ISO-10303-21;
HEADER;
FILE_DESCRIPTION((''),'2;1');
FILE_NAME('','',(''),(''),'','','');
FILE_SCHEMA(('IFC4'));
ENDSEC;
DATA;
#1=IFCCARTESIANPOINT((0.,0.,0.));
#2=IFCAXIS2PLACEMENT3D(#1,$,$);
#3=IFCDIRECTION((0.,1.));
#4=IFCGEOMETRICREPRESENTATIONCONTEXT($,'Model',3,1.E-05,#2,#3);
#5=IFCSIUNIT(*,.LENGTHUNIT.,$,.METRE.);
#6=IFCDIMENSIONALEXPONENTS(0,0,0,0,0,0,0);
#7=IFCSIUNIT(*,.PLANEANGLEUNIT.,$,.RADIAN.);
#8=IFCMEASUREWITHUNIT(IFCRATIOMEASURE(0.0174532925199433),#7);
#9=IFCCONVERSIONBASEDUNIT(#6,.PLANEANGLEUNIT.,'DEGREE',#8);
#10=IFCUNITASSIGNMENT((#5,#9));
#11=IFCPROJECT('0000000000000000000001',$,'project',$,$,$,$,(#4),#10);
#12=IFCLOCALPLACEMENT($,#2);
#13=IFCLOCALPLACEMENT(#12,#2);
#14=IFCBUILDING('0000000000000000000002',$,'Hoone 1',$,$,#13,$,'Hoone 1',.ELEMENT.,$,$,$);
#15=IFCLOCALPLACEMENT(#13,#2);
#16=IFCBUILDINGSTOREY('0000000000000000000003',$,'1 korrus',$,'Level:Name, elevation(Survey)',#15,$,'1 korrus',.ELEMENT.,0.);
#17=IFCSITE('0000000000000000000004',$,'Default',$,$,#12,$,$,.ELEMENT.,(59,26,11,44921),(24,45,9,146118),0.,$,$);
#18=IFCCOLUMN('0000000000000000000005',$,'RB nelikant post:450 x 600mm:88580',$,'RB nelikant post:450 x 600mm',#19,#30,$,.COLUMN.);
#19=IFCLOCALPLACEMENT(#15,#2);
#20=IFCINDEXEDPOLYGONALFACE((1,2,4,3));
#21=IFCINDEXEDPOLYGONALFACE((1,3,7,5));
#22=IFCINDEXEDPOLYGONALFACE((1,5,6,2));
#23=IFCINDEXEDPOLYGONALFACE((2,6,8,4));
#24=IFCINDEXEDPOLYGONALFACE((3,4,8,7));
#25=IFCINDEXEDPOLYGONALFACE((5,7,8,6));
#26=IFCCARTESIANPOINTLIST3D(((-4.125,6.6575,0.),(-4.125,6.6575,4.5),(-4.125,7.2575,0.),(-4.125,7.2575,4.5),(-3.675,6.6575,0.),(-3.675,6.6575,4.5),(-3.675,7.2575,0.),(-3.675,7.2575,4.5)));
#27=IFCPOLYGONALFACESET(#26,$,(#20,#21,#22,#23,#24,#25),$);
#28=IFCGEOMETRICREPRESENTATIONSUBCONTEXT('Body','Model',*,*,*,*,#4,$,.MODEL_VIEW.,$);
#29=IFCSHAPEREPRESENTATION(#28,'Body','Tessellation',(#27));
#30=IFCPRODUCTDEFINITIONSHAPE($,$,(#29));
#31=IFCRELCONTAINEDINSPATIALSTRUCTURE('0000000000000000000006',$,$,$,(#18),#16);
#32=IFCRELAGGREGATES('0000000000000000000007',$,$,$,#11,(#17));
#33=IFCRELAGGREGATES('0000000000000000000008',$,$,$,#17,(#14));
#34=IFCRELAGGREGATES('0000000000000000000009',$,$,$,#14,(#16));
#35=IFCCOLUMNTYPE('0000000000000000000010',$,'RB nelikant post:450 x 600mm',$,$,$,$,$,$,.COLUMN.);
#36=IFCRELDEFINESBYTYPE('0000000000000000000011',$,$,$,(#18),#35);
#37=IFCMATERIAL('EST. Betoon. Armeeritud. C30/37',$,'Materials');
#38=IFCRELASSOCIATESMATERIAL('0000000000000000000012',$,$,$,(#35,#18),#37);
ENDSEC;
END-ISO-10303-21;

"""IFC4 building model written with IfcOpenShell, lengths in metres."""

from ifc_helpers import new_model, entity, si_unit, converted_unit, direction, frame, origin, place, context, subcontext, project, spatial, indexed_curve, outline, extrude, source, transform, mapped, material, type_object, type_shapes, element, save


model = new_model("IFC4")

# Units and contexts
model_context = context("Model", 3, precision=1e-05, world=origin(), true_north=direction((0.0, 1.0)))
body_context = subcontext(model_context, "Body", "Model", "MODEL_VIEW")
ifc_project = project(units=[si_unit("LENGTHUNIT", "METRE"), converted_unit("PLANEANGLEUNIT", "DEGREE", entity("IfcRatioMeasure", 0.0174532925199433), si_unit("PLANEANGLEUNIT", "RADIAN"), dimensions=[0, 0, 0, 0, 0, 0, 0])], contexts=[model_context])

# Site, building, storey
site_placement = place(None, origin())
site = spatial("IfcSite", under=ifc_project, at=site_placement, Name="Default", CompositionType="ELEMENT", RefLatitude=(59, 26, 11, 44921), RefLongitude=(24, 45, 9, 146118), RefElevation=0.0)
building_placement = place(site_placement, origin())
building = spatial("IfcBuilding", under=site, at=building_placement, Name="Hoone 1", LongName="Hoone 1", CompositionType="ELEMENT")
storey_placement = place(building_placement, origin())
storey = spatial("IfcBuildingStorey", under=building, at=storey_placement, Name="1 korrus", ObjectType="Level:Name, elevation(Survey)", LongName="1 korrus", CompositionType="ELEMENT", Elevation=0.0)

# Column
ifc_material_1 = material(Name="EST. Betoon. Armeeritud. C30/37", Category="Materials")
column_type = type_object("IfcColumnType", Name="RB nelikant post:450 x 600mm", PredefinedType="COLUMN", material=ifc_material_1)
shared_shape = source(origin(), body_context, "Body", "SweptSolid", [
    extrude(outline(indexed_curve([(-0.3, -0.225), (0.3, -0.225), (0.3, 0.225), (-0.3, 0.225), (-0.3, -0.225)], self_intersect=False)), frame((0.0, 0.0, 0.0), z_axis=(0.0, 0.0, 1.0), x_axis=(0.0, -1.0, 0.0)), (0.0, 0.0, 1.0), 4.5),
])
type_shapes(column_type, [shared_shape])
column_placement = place(storey_placement, frame((-3.9, 6.9575, 0.0)))
element("IfcColumn", 1, at=column_placement, inside=storey, type_object=column_type, material=ifc_material_1, Name="RB nelikant post:450 x 600mm:88580", ObjectType="RB nelikant post:450 x 600mm", PredefinedType="COLUMN", context=body_context, shape_type="MappedRepresentation", body=[
    mapped(shared_shape, transform((0.0, 0.0, 0.0), scale=1.0)),
])

save(model, "model.ifc")
